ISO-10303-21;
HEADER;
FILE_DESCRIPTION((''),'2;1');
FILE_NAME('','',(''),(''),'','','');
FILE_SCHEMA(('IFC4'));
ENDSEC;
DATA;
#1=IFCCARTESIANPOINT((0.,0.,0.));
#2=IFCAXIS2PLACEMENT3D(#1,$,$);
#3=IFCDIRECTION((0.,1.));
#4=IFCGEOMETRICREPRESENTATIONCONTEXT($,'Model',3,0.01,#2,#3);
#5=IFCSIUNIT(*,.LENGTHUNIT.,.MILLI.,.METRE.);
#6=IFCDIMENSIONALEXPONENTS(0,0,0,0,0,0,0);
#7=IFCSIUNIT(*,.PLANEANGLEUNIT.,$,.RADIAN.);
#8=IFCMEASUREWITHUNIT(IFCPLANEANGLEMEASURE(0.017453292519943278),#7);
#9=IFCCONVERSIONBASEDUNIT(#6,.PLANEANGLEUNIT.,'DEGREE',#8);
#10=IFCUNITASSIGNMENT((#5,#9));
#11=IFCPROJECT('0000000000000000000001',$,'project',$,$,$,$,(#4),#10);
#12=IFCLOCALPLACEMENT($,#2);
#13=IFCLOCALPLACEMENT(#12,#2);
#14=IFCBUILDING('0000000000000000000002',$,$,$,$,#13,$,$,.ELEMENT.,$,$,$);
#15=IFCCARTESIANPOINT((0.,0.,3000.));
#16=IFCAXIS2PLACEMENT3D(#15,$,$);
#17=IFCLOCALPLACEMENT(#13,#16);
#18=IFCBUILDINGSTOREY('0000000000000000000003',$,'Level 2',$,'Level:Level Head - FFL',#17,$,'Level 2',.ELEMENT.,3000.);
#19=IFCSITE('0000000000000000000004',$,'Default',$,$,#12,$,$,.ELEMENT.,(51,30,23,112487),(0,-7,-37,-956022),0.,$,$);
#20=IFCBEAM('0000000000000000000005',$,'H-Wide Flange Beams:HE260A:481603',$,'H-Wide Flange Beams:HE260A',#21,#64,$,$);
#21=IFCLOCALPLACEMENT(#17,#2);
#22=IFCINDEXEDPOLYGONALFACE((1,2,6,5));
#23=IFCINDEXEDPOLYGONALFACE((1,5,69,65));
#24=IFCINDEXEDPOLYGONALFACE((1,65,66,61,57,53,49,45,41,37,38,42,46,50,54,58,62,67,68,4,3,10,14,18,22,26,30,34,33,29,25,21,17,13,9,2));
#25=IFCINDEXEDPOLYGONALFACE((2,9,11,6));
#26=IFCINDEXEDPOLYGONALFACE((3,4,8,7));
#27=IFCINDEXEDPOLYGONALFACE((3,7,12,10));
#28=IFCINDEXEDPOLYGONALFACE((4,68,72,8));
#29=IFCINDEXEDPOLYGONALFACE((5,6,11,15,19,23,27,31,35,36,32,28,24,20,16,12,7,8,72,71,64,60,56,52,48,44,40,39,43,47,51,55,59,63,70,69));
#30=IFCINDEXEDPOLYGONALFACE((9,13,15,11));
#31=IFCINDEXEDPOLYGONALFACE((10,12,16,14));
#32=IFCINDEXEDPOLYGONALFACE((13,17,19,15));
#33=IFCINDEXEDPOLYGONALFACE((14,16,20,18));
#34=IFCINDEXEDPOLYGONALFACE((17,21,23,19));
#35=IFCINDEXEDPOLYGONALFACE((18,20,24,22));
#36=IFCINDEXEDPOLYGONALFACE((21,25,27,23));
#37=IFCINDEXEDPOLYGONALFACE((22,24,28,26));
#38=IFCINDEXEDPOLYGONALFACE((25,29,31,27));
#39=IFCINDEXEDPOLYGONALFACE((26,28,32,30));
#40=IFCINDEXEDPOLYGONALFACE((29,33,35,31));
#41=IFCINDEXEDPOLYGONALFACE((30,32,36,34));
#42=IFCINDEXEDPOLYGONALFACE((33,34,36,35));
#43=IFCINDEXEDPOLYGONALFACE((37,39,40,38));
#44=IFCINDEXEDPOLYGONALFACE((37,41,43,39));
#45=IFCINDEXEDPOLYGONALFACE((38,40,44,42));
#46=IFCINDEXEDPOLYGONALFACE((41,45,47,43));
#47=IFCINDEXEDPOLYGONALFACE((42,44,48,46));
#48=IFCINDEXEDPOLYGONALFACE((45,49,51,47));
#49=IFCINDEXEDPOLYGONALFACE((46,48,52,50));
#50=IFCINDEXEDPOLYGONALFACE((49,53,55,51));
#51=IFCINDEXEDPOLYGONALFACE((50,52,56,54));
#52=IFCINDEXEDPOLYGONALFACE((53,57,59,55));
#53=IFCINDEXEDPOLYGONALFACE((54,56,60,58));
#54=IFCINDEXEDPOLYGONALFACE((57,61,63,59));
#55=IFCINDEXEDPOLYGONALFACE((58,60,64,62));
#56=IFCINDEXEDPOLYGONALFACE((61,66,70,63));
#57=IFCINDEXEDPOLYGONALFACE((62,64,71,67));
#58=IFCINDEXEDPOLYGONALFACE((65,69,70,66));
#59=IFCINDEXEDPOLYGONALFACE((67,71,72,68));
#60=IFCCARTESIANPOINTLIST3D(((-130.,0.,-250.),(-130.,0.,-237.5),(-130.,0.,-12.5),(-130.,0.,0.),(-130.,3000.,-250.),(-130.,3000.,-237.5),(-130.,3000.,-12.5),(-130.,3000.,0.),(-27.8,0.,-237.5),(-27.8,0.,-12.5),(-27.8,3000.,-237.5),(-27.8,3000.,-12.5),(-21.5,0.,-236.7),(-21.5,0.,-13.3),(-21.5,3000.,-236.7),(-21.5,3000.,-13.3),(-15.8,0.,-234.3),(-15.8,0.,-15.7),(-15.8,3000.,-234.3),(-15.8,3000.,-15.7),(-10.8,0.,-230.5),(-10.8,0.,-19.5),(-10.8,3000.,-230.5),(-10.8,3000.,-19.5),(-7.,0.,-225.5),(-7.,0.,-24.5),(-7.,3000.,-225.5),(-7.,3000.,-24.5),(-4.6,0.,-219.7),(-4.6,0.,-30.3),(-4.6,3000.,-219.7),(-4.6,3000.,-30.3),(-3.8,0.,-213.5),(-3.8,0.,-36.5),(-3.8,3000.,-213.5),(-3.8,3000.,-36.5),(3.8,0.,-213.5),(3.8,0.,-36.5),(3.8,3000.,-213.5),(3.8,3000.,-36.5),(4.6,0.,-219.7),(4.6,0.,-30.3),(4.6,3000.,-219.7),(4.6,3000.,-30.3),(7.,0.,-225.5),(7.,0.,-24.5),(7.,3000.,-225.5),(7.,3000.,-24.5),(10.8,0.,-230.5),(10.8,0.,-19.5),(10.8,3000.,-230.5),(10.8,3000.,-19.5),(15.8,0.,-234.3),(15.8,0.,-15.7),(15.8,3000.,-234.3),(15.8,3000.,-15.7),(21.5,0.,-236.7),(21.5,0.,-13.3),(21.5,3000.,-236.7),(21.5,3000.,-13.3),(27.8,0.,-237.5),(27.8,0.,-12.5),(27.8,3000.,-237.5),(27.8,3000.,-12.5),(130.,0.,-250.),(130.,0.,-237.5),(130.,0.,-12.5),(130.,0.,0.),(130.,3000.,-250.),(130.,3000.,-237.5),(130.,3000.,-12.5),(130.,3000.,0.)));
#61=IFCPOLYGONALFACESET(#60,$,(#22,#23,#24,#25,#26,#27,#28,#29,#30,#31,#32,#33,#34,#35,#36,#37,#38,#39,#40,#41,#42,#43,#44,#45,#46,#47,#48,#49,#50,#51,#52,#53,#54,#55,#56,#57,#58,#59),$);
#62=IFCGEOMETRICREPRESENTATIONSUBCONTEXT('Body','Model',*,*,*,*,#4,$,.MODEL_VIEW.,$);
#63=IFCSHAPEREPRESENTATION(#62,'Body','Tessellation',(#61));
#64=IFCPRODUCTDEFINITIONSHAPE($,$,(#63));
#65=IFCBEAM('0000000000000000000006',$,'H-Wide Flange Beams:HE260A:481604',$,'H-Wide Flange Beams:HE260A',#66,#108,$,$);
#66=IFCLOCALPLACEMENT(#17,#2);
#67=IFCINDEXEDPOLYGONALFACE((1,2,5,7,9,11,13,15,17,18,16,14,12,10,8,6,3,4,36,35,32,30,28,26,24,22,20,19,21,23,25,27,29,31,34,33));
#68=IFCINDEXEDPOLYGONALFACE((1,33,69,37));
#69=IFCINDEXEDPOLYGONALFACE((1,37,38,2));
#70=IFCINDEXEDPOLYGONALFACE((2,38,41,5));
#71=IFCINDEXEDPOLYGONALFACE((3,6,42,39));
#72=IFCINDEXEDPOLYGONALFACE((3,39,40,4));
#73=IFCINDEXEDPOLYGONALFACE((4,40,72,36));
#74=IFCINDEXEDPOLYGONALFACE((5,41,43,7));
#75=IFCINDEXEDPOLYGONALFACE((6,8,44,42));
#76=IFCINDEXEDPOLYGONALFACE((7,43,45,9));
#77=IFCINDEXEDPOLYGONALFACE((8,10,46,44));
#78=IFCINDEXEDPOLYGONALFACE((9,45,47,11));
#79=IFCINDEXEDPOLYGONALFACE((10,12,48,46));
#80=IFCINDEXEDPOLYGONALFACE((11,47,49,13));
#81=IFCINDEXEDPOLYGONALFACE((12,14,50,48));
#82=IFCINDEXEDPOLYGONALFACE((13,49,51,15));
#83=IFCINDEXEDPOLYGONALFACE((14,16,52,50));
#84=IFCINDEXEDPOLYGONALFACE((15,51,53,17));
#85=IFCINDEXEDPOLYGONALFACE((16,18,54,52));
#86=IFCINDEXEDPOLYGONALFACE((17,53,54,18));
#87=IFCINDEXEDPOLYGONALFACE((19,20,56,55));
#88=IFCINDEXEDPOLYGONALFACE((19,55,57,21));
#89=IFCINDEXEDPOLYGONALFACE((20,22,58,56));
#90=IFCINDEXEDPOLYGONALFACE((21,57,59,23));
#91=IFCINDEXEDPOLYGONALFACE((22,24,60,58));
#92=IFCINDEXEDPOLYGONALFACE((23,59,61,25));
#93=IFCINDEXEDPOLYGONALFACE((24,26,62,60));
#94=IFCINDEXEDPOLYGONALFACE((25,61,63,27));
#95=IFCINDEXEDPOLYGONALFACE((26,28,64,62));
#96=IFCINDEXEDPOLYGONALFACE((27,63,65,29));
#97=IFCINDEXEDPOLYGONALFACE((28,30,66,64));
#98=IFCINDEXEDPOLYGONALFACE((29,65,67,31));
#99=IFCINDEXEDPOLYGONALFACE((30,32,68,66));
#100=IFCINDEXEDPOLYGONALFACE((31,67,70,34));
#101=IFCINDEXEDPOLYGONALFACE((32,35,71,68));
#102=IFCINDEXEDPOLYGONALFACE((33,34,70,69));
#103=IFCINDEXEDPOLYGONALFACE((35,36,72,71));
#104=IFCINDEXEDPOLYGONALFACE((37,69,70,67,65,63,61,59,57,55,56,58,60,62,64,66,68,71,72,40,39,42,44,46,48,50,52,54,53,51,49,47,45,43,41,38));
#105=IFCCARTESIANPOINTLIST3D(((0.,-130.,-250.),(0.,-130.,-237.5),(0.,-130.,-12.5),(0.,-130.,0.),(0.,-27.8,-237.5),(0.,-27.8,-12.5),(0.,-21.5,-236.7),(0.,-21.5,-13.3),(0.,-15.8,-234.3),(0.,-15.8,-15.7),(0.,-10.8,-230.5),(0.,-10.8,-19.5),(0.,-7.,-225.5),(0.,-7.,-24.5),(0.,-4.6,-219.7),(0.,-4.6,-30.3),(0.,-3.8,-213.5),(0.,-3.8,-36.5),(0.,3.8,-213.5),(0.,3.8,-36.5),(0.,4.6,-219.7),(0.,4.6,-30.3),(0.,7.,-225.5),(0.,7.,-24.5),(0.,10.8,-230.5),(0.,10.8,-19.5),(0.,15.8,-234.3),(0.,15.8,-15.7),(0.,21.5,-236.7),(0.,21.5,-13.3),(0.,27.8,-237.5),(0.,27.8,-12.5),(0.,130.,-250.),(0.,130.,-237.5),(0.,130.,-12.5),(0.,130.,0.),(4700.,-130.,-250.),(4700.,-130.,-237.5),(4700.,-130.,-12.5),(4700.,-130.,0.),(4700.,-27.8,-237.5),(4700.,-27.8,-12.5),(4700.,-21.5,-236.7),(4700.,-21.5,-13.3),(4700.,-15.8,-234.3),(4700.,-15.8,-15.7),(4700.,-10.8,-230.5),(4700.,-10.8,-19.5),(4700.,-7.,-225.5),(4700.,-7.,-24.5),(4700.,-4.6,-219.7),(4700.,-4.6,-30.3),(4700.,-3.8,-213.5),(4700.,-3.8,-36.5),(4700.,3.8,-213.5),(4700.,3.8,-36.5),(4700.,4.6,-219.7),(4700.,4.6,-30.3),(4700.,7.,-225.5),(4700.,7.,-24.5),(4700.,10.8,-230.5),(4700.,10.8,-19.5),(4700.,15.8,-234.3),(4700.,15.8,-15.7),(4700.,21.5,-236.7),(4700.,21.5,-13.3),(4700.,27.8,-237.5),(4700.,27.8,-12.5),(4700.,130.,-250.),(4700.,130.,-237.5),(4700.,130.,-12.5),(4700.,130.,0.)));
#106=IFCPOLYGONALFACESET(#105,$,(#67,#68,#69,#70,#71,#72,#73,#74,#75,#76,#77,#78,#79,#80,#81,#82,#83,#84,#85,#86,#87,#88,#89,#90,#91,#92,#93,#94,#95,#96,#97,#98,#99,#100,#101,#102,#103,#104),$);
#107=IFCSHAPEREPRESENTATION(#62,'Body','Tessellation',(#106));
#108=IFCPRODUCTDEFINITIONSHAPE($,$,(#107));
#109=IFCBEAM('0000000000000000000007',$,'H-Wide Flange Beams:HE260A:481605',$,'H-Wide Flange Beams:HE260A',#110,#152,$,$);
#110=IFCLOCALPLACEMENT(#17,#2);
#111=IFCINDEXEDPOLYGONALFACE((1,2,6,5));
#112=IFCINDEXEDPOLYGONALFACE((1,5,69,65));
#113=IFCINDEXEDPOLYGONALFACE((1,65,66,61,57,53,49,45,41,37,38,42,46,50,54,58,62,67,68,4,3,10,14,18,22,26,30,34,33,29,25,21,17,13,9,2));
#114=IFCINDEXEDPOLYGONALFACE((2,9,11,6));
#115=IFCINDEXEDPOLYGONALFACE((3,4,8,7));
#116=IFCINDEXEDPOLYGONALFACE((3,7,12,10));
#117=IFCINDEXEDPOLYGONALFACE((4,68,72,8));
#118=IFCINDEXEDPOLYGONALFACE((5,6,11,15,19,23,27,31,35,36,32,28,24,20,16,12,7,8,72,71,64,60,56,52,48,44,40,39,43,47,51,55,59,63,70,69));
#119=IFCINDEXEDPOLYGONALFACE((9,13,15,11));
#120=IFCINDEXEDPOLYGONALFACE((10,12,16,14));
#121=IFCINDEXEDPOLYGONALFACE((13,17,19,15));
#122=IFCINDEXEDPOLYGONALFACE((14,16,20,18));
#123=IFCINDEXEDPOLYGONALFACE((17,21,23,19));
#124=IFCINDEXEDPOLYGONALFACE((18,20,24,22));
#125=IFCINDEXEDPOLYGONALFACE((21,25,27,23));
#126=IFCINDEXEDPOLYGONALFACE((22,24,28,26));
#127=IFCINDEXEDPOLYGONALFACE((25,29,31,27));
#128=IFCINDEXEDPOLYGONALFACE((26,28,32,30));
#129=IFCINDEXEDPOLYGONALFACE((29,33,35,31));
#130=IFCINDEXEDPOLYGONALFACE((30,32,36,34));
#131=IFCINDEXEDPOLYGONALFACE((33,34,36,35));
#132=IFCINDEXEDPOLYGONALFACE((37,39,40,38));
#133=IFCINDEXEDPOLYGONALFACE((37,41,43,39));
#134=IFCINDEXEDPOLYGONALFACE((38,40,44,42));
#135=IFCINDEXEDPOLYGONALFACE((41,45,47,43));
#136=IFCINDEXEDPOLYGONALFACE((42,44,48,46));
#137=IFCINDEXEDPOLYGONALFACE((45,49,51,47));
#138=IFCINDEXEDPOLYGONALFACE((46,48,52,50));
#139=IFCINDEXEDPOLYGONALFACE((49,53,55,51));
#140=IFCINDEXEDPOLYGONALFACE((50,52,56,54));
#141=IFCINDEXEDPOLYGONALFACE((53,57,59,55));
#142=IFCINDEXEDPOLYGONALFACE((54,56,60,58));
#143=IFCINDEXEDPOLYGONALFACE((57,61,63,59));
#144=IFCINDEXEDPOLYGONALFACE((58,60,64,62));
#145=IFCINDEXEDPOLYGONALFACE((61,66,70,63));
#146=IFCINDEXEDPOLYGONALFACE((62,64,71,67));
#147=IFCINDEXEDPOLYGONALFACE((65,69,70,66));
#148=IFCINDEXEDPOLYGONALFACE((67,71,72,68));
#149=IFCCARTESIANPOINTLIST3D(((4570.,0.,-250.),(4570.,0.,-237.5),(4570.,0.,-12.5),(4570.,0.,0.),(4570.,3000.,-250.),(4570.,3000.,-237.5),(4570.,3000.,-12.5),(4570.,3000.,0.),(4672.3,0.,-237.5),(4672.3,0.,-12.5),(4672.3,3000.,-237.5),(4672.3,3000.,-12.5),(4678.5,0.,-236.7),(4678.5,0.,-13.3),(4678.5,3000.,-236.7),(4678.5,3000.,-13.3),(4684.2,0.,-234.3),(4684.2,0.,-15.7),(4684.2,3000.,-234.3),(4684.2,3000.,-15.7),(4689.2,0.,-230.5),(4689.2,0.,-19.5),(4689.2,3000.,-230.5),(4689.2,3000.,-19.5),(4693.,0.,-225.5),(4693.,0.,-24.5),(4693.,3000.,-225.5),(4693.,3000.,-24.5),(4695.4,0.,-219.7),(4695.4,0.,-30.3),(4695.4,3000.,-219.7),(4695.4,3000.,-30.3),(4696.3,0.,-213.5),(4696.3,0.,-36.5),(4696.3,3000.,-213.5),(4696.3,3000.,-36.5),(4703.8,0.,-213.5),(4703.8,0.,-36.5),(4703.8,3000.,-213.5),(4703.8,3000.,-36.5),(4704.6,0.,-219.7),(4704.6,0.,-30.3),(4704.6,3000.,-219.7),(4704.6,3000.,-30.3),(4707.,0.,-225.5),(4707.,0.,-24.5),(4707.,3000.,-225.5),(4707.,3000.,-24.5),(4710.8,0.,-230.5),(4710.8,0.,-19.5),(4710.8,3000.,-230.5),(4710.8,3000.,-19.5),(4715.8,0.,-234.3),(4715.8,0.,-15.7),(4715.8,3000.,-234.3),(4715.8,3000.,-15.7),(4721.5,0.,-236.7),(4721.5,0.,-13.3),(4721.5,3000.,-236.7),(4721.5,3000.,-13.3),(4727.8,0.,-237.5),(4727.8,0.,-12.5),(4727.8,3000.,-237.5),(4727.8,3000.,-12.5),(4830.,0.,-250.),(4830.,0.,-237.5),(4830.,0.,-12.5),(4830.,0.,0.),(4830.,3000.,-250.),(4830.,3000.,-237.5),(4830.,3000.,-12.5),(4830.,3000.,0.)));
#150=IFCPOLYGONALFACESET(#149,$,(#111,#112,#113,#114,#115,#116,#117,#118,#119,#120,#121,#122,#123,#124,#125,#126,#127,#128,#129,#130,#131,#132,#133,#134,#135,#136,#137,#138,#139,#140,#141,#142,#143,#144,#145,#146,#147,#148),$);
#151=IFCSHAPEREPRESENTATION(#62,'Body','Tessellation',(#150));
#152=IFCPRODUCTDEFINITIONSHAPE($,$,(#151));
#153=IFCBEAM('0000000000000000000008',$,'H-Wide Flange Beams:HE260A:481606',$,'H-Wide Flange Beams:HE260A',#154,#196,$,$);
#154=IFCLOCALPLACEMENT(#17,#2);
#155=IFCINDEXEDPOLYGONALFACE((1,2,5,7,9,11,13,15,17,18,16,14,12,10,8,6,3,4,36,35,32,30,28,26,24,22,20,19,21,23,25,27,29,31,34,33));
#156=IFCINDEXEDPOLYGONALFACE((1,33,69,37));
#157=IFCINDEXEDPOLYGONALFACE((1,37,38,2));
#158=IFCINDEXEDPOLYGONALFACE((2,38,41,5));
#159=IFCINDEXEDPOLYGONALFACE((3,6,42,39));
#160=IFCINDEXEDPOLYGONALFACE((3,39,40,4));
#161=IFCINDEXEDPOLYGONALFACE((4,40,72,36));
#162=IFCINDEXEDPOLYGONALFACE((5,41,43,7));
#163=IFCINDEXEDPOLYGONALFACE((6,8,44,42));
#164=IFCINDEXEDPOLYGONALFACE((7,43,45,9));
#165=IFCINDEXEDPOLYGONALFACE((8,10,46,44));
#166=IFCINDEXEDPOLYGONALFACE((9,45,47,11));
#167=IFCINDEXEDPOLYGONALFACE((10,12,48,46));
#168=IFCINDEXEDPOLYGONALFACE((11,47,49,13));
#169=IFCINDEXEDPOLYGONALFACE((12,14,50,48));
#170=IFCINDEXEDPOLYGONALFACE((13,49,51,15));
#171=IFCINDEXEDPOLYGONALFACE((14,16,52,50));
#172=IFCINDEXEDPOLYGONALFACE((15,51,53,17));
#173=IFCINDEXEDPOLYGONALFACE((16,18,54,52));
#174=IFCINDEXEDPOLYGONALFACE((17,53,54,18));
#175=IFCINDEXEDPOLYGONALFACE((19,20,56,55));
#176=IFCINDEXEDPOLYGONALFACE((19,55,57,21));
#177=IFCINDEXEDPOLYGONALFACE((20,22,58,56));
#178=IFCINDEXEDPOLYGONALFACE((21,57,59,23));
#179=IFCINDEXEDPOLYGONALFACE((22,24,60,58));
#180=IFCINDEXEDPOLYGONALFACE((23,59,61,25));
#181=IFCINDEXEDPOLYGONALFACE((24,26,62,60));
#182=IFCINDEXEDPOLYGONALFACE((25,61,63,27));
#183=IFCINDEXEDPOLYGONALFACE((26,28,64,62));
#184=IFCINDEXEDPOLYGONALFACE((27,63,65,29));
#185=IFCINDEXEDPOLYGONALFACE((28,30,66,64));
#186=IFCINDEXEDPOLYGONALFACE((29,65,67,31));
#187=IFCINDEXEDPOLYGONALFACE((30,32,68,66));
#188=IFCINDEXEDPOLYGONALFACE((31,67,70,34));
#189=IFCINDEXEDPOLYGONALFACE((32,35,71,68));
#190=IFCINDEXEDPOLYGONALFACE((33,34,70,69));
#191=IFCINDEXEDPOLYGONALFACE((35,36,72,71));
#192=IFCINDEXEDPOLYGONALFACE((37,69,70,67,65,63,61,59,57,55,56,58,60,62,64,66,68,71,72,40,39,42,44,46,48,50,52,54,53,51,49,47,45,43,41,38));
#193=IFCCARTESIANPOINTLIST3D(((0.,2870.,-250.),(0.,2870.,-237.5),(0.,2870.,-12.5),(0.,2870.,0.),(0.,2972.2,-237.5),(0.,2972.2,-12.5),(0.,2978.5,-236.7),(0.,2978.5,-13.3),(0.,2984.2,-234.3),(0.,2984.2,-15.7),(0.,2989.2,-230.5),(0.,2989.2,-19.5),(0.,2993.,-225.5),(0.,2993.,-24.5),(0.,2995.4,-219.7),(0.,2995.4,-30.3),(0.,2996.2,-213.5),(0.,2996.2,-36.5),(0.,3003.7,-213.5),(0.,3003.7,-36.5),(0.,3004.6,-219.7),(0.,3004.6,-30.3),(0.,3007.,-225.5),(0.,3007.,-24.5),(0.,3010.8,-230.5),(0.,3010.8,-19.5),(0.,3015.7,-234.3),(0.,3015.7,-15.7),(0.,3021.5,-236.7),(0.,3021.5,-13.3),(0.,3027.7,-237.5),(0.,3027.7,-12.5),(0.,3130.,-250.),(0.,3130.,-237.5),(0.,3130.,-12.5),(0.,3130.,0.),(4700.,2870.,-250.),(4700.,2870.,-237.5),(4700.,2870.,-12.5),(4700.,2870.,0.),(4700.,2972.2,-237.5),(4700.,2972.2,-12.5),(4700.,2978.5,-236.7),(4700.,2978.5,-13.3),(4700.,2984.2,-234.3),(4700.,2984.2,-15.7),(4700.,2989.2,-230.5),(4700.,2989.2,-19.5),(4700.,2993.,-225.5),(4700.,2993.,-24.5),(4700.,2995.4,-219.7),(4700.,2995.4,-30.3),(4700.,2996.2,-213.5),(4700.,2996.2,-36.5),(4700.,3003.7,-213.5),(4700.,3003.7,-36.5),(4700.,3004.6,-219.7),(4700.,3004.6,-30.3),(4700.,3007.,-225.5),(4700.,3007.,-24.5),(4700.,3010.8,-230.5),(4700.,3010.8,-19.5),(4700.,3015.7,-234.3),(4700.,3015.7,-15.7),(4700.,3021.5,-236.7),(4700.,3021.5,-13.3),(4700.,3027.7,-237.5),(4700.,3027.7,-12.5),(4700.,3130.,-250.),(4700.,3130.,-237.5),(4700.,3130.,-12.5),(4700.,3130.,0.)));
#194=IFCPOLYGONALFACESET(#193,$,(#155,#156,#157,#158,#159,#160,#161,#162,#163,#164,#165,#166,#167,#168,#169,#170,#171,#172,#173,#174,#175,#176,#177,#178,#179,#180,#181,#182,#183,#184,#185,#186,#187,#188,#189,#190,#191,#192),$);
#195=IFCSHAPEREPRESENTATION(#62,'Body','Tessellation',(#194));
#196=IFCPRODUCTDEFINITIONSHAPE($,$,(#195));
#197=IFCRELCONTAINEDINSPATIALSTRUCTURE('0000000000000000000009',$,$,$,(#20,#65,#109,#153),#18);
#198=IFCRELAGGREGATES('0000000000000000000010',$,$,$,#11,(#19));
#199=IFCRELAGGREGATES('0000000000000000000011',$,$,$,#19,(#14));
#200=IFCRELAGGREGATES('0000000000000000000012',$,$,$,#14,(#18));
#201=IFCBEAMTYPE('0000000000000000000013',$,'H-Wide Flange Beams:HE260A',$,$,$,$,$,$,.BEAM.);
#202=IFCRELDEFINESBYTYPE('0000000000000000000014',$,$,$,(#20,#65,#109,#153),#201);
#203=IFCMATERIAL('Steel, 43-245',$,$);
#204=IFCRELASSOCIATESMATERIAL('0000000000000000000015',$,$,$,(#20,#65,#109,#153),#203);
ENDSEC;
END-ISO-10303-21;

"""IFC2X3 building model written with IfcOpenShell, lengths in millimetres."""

from ifc_helpers import new_model, entity, si_unit, converted_unit, direction, frame, frame_2d, origin, place, context, subcontext, project, spatial, i_section, extrude, material, type_object, element, save


model = new_model("IFC2X3")

# Units and contexts
model_context = context("Model", 3, precision=0.01, world=origin(), true_north=direction((0.0, 1.0)))
body_context = subcontext(model_context, "Body", "Model", "MODEL_VIEW")
ifc_project = project(units=[si_unit("LENGTHUNIT", "METRE", prefix="MILLI"), converted_unit("PLANEANGLEUNIT", "DEGREE", entity("IfcPlaneAngleMeasure", 0.017453292519943278), si_unit("PLANEANGLEUNIT", "RADIAN"), dimensions=[0, 0, 0, 0, 0, 0, 0])], contexts=[model_context])

# Site, building, storey
site_placement = place(None, origin())
site = spatial("IfcSite", under=ifc_project, at=site_placement, Name="Default", CompositionType="ELEMENT", RefLatitude=(51, 30, 23, 112487), RefLongitude=(0, -7, -37, -956022), RefElevation=0.0)
building_placement = place(site_placement, origin())
building = spatial("IfcBuilding", under=site, at=building_placement, CompositionType="ELEMENT")
storey_placement = place(building_placement, frame((0.0, 0.0, 3000.0)))
storey = spatial("IfcBuildingStorey", under=building, at=storey_placement, Name="Level 2", ObjectType="Level:Level Head - FFL", LongName="Level 2", CompositionType="ELEMENT", Elevation=3000.0)

# Beams
ifc_material = material(Name="Steel, 43-245")
beam_type_1 = type_object("IfcBeamType", Name="H-Wide Flange Beams:HE260A", PredefinedType="BEAM")
beam_1_placement = place(storey_placement, frame((0.0, 3000.0, 0.0), z_axis=(0.0, 0.0, 1.0), x_axis=(0.0, -1.0, 0.0)))
element("IfcBeam", 1, at=beam_1_placement, inside=storey, type_object=beam_type_1, material=ifc_material, Name="H-Wide Flange Beams:HE260A:481603", ObjectType="H-Wide Flange Beams:HE260A", context=body_context, shape_type="SweptSolid", body=[
    extrude(i_section(OverallWidth=260.0, OverallDepth=250.0, WebThickness=7.5, FlangeThickness=12.5, FilletRadius=24.0, at=frame_2d((0.0, 0.0), x_axis=(0.0, 1.0))), frame((0.0, 0.0, -125.0), z_axis=(1.0, 0.0, 0.0), x_axis=(0.0, 0.0, -1.0)), (0.0, 0.0, 1.0), 3000.0),
])
beam_2_placement = place(storey_placement, origin())
element("IfcBeam", 2, at=beam_2_placement, inside=storey, type_object=beam_type_1, material=ifc_material, Name="H-Wide Flange Beams:HE260A:481604", ObjectType="H-Wide Flange Beams:HE260A", context=body_context, shape_type="SweptSolid", body=[
    extrude(i_section(OverallWidth=260.0, OverallDepth=250.0, WebThickness=7.5, FlangeThickness=12.5, FilletRadius=24.0, at=frame_2d((0.0, 0.0), x_axis=(0.0, 1.0))), frame((0.0, 0.0, -125.0), z_axis=(1.0, 0.0, 0.0), x_axis=(0.0, 0.0, -1.0)), (0.0, 0.0, 1.0), 4700.0),
])
beam_3_placement = place(storey_placement, frame((4700.0, 0.0, 0.0), z_axis=(0.0, 0.0, 1.0), x_axis=(0.0, 1.0, 0.0)))
element("IfcBeam", 3, at=beam_3_placement, inside=storey, type_object=beam_type_1, material=ifc_material, Name="H-Wide Flange Beams:HE260A:481605", ObjectType="H-Wide Flange Beams:HE260A", context=body_context, shape_type="SweptSolid", body=[
    extrude(i_section(OverallWidth=260.0, OverallDepth=250.0, WebThickness=7.5, FlangeThickness=12.5, FilletRadius=24.0, at=frame_2d((0.0, 0.0), x_axis=(0.0, 1.0))), frame((0.0, 0.0, -125.0), z_axis=(1.0, 0.0, 0.0), x_axis=(0.0, 0.0, -1.0)), (0.0, 0.0, 1.0), 3000.0),
])
beam_4_placement = place(storey_placement, frame((4700.0, 3000.0, 0.0), z_axis=(0.0, 0.0, 1.0), x_axis=(-1.0, 0.0, 0.0)))
element("IfcBeam", 4, at=beam_4_placement, inside=storey, type_object=beam_type_1, material=ifc_material, Name="H-Wide Flange Beams:HE260A:481606", ObjectType="H-Wide Flange Beams:HE260A", context=body_context, shape_type="SweptSolid", body=[
    extrude(i_section(OverallWidth=260.0, OverallDepth=250.0, WebThickness=7.5, FlangeThickness=12.5, FilletRadius=24.0, at=frame_2d((0.0, 0.0), x_axis=(0.0, 1.0))), frame((0.0, 0.0, -125.0), z_axis=(1.0, 0.0, 0.0), x_axis=(0.0, 0.0, -1.0)), (0.0, 0.0, 1.0), 4700.0),
])

save(model, "model.ifc")
